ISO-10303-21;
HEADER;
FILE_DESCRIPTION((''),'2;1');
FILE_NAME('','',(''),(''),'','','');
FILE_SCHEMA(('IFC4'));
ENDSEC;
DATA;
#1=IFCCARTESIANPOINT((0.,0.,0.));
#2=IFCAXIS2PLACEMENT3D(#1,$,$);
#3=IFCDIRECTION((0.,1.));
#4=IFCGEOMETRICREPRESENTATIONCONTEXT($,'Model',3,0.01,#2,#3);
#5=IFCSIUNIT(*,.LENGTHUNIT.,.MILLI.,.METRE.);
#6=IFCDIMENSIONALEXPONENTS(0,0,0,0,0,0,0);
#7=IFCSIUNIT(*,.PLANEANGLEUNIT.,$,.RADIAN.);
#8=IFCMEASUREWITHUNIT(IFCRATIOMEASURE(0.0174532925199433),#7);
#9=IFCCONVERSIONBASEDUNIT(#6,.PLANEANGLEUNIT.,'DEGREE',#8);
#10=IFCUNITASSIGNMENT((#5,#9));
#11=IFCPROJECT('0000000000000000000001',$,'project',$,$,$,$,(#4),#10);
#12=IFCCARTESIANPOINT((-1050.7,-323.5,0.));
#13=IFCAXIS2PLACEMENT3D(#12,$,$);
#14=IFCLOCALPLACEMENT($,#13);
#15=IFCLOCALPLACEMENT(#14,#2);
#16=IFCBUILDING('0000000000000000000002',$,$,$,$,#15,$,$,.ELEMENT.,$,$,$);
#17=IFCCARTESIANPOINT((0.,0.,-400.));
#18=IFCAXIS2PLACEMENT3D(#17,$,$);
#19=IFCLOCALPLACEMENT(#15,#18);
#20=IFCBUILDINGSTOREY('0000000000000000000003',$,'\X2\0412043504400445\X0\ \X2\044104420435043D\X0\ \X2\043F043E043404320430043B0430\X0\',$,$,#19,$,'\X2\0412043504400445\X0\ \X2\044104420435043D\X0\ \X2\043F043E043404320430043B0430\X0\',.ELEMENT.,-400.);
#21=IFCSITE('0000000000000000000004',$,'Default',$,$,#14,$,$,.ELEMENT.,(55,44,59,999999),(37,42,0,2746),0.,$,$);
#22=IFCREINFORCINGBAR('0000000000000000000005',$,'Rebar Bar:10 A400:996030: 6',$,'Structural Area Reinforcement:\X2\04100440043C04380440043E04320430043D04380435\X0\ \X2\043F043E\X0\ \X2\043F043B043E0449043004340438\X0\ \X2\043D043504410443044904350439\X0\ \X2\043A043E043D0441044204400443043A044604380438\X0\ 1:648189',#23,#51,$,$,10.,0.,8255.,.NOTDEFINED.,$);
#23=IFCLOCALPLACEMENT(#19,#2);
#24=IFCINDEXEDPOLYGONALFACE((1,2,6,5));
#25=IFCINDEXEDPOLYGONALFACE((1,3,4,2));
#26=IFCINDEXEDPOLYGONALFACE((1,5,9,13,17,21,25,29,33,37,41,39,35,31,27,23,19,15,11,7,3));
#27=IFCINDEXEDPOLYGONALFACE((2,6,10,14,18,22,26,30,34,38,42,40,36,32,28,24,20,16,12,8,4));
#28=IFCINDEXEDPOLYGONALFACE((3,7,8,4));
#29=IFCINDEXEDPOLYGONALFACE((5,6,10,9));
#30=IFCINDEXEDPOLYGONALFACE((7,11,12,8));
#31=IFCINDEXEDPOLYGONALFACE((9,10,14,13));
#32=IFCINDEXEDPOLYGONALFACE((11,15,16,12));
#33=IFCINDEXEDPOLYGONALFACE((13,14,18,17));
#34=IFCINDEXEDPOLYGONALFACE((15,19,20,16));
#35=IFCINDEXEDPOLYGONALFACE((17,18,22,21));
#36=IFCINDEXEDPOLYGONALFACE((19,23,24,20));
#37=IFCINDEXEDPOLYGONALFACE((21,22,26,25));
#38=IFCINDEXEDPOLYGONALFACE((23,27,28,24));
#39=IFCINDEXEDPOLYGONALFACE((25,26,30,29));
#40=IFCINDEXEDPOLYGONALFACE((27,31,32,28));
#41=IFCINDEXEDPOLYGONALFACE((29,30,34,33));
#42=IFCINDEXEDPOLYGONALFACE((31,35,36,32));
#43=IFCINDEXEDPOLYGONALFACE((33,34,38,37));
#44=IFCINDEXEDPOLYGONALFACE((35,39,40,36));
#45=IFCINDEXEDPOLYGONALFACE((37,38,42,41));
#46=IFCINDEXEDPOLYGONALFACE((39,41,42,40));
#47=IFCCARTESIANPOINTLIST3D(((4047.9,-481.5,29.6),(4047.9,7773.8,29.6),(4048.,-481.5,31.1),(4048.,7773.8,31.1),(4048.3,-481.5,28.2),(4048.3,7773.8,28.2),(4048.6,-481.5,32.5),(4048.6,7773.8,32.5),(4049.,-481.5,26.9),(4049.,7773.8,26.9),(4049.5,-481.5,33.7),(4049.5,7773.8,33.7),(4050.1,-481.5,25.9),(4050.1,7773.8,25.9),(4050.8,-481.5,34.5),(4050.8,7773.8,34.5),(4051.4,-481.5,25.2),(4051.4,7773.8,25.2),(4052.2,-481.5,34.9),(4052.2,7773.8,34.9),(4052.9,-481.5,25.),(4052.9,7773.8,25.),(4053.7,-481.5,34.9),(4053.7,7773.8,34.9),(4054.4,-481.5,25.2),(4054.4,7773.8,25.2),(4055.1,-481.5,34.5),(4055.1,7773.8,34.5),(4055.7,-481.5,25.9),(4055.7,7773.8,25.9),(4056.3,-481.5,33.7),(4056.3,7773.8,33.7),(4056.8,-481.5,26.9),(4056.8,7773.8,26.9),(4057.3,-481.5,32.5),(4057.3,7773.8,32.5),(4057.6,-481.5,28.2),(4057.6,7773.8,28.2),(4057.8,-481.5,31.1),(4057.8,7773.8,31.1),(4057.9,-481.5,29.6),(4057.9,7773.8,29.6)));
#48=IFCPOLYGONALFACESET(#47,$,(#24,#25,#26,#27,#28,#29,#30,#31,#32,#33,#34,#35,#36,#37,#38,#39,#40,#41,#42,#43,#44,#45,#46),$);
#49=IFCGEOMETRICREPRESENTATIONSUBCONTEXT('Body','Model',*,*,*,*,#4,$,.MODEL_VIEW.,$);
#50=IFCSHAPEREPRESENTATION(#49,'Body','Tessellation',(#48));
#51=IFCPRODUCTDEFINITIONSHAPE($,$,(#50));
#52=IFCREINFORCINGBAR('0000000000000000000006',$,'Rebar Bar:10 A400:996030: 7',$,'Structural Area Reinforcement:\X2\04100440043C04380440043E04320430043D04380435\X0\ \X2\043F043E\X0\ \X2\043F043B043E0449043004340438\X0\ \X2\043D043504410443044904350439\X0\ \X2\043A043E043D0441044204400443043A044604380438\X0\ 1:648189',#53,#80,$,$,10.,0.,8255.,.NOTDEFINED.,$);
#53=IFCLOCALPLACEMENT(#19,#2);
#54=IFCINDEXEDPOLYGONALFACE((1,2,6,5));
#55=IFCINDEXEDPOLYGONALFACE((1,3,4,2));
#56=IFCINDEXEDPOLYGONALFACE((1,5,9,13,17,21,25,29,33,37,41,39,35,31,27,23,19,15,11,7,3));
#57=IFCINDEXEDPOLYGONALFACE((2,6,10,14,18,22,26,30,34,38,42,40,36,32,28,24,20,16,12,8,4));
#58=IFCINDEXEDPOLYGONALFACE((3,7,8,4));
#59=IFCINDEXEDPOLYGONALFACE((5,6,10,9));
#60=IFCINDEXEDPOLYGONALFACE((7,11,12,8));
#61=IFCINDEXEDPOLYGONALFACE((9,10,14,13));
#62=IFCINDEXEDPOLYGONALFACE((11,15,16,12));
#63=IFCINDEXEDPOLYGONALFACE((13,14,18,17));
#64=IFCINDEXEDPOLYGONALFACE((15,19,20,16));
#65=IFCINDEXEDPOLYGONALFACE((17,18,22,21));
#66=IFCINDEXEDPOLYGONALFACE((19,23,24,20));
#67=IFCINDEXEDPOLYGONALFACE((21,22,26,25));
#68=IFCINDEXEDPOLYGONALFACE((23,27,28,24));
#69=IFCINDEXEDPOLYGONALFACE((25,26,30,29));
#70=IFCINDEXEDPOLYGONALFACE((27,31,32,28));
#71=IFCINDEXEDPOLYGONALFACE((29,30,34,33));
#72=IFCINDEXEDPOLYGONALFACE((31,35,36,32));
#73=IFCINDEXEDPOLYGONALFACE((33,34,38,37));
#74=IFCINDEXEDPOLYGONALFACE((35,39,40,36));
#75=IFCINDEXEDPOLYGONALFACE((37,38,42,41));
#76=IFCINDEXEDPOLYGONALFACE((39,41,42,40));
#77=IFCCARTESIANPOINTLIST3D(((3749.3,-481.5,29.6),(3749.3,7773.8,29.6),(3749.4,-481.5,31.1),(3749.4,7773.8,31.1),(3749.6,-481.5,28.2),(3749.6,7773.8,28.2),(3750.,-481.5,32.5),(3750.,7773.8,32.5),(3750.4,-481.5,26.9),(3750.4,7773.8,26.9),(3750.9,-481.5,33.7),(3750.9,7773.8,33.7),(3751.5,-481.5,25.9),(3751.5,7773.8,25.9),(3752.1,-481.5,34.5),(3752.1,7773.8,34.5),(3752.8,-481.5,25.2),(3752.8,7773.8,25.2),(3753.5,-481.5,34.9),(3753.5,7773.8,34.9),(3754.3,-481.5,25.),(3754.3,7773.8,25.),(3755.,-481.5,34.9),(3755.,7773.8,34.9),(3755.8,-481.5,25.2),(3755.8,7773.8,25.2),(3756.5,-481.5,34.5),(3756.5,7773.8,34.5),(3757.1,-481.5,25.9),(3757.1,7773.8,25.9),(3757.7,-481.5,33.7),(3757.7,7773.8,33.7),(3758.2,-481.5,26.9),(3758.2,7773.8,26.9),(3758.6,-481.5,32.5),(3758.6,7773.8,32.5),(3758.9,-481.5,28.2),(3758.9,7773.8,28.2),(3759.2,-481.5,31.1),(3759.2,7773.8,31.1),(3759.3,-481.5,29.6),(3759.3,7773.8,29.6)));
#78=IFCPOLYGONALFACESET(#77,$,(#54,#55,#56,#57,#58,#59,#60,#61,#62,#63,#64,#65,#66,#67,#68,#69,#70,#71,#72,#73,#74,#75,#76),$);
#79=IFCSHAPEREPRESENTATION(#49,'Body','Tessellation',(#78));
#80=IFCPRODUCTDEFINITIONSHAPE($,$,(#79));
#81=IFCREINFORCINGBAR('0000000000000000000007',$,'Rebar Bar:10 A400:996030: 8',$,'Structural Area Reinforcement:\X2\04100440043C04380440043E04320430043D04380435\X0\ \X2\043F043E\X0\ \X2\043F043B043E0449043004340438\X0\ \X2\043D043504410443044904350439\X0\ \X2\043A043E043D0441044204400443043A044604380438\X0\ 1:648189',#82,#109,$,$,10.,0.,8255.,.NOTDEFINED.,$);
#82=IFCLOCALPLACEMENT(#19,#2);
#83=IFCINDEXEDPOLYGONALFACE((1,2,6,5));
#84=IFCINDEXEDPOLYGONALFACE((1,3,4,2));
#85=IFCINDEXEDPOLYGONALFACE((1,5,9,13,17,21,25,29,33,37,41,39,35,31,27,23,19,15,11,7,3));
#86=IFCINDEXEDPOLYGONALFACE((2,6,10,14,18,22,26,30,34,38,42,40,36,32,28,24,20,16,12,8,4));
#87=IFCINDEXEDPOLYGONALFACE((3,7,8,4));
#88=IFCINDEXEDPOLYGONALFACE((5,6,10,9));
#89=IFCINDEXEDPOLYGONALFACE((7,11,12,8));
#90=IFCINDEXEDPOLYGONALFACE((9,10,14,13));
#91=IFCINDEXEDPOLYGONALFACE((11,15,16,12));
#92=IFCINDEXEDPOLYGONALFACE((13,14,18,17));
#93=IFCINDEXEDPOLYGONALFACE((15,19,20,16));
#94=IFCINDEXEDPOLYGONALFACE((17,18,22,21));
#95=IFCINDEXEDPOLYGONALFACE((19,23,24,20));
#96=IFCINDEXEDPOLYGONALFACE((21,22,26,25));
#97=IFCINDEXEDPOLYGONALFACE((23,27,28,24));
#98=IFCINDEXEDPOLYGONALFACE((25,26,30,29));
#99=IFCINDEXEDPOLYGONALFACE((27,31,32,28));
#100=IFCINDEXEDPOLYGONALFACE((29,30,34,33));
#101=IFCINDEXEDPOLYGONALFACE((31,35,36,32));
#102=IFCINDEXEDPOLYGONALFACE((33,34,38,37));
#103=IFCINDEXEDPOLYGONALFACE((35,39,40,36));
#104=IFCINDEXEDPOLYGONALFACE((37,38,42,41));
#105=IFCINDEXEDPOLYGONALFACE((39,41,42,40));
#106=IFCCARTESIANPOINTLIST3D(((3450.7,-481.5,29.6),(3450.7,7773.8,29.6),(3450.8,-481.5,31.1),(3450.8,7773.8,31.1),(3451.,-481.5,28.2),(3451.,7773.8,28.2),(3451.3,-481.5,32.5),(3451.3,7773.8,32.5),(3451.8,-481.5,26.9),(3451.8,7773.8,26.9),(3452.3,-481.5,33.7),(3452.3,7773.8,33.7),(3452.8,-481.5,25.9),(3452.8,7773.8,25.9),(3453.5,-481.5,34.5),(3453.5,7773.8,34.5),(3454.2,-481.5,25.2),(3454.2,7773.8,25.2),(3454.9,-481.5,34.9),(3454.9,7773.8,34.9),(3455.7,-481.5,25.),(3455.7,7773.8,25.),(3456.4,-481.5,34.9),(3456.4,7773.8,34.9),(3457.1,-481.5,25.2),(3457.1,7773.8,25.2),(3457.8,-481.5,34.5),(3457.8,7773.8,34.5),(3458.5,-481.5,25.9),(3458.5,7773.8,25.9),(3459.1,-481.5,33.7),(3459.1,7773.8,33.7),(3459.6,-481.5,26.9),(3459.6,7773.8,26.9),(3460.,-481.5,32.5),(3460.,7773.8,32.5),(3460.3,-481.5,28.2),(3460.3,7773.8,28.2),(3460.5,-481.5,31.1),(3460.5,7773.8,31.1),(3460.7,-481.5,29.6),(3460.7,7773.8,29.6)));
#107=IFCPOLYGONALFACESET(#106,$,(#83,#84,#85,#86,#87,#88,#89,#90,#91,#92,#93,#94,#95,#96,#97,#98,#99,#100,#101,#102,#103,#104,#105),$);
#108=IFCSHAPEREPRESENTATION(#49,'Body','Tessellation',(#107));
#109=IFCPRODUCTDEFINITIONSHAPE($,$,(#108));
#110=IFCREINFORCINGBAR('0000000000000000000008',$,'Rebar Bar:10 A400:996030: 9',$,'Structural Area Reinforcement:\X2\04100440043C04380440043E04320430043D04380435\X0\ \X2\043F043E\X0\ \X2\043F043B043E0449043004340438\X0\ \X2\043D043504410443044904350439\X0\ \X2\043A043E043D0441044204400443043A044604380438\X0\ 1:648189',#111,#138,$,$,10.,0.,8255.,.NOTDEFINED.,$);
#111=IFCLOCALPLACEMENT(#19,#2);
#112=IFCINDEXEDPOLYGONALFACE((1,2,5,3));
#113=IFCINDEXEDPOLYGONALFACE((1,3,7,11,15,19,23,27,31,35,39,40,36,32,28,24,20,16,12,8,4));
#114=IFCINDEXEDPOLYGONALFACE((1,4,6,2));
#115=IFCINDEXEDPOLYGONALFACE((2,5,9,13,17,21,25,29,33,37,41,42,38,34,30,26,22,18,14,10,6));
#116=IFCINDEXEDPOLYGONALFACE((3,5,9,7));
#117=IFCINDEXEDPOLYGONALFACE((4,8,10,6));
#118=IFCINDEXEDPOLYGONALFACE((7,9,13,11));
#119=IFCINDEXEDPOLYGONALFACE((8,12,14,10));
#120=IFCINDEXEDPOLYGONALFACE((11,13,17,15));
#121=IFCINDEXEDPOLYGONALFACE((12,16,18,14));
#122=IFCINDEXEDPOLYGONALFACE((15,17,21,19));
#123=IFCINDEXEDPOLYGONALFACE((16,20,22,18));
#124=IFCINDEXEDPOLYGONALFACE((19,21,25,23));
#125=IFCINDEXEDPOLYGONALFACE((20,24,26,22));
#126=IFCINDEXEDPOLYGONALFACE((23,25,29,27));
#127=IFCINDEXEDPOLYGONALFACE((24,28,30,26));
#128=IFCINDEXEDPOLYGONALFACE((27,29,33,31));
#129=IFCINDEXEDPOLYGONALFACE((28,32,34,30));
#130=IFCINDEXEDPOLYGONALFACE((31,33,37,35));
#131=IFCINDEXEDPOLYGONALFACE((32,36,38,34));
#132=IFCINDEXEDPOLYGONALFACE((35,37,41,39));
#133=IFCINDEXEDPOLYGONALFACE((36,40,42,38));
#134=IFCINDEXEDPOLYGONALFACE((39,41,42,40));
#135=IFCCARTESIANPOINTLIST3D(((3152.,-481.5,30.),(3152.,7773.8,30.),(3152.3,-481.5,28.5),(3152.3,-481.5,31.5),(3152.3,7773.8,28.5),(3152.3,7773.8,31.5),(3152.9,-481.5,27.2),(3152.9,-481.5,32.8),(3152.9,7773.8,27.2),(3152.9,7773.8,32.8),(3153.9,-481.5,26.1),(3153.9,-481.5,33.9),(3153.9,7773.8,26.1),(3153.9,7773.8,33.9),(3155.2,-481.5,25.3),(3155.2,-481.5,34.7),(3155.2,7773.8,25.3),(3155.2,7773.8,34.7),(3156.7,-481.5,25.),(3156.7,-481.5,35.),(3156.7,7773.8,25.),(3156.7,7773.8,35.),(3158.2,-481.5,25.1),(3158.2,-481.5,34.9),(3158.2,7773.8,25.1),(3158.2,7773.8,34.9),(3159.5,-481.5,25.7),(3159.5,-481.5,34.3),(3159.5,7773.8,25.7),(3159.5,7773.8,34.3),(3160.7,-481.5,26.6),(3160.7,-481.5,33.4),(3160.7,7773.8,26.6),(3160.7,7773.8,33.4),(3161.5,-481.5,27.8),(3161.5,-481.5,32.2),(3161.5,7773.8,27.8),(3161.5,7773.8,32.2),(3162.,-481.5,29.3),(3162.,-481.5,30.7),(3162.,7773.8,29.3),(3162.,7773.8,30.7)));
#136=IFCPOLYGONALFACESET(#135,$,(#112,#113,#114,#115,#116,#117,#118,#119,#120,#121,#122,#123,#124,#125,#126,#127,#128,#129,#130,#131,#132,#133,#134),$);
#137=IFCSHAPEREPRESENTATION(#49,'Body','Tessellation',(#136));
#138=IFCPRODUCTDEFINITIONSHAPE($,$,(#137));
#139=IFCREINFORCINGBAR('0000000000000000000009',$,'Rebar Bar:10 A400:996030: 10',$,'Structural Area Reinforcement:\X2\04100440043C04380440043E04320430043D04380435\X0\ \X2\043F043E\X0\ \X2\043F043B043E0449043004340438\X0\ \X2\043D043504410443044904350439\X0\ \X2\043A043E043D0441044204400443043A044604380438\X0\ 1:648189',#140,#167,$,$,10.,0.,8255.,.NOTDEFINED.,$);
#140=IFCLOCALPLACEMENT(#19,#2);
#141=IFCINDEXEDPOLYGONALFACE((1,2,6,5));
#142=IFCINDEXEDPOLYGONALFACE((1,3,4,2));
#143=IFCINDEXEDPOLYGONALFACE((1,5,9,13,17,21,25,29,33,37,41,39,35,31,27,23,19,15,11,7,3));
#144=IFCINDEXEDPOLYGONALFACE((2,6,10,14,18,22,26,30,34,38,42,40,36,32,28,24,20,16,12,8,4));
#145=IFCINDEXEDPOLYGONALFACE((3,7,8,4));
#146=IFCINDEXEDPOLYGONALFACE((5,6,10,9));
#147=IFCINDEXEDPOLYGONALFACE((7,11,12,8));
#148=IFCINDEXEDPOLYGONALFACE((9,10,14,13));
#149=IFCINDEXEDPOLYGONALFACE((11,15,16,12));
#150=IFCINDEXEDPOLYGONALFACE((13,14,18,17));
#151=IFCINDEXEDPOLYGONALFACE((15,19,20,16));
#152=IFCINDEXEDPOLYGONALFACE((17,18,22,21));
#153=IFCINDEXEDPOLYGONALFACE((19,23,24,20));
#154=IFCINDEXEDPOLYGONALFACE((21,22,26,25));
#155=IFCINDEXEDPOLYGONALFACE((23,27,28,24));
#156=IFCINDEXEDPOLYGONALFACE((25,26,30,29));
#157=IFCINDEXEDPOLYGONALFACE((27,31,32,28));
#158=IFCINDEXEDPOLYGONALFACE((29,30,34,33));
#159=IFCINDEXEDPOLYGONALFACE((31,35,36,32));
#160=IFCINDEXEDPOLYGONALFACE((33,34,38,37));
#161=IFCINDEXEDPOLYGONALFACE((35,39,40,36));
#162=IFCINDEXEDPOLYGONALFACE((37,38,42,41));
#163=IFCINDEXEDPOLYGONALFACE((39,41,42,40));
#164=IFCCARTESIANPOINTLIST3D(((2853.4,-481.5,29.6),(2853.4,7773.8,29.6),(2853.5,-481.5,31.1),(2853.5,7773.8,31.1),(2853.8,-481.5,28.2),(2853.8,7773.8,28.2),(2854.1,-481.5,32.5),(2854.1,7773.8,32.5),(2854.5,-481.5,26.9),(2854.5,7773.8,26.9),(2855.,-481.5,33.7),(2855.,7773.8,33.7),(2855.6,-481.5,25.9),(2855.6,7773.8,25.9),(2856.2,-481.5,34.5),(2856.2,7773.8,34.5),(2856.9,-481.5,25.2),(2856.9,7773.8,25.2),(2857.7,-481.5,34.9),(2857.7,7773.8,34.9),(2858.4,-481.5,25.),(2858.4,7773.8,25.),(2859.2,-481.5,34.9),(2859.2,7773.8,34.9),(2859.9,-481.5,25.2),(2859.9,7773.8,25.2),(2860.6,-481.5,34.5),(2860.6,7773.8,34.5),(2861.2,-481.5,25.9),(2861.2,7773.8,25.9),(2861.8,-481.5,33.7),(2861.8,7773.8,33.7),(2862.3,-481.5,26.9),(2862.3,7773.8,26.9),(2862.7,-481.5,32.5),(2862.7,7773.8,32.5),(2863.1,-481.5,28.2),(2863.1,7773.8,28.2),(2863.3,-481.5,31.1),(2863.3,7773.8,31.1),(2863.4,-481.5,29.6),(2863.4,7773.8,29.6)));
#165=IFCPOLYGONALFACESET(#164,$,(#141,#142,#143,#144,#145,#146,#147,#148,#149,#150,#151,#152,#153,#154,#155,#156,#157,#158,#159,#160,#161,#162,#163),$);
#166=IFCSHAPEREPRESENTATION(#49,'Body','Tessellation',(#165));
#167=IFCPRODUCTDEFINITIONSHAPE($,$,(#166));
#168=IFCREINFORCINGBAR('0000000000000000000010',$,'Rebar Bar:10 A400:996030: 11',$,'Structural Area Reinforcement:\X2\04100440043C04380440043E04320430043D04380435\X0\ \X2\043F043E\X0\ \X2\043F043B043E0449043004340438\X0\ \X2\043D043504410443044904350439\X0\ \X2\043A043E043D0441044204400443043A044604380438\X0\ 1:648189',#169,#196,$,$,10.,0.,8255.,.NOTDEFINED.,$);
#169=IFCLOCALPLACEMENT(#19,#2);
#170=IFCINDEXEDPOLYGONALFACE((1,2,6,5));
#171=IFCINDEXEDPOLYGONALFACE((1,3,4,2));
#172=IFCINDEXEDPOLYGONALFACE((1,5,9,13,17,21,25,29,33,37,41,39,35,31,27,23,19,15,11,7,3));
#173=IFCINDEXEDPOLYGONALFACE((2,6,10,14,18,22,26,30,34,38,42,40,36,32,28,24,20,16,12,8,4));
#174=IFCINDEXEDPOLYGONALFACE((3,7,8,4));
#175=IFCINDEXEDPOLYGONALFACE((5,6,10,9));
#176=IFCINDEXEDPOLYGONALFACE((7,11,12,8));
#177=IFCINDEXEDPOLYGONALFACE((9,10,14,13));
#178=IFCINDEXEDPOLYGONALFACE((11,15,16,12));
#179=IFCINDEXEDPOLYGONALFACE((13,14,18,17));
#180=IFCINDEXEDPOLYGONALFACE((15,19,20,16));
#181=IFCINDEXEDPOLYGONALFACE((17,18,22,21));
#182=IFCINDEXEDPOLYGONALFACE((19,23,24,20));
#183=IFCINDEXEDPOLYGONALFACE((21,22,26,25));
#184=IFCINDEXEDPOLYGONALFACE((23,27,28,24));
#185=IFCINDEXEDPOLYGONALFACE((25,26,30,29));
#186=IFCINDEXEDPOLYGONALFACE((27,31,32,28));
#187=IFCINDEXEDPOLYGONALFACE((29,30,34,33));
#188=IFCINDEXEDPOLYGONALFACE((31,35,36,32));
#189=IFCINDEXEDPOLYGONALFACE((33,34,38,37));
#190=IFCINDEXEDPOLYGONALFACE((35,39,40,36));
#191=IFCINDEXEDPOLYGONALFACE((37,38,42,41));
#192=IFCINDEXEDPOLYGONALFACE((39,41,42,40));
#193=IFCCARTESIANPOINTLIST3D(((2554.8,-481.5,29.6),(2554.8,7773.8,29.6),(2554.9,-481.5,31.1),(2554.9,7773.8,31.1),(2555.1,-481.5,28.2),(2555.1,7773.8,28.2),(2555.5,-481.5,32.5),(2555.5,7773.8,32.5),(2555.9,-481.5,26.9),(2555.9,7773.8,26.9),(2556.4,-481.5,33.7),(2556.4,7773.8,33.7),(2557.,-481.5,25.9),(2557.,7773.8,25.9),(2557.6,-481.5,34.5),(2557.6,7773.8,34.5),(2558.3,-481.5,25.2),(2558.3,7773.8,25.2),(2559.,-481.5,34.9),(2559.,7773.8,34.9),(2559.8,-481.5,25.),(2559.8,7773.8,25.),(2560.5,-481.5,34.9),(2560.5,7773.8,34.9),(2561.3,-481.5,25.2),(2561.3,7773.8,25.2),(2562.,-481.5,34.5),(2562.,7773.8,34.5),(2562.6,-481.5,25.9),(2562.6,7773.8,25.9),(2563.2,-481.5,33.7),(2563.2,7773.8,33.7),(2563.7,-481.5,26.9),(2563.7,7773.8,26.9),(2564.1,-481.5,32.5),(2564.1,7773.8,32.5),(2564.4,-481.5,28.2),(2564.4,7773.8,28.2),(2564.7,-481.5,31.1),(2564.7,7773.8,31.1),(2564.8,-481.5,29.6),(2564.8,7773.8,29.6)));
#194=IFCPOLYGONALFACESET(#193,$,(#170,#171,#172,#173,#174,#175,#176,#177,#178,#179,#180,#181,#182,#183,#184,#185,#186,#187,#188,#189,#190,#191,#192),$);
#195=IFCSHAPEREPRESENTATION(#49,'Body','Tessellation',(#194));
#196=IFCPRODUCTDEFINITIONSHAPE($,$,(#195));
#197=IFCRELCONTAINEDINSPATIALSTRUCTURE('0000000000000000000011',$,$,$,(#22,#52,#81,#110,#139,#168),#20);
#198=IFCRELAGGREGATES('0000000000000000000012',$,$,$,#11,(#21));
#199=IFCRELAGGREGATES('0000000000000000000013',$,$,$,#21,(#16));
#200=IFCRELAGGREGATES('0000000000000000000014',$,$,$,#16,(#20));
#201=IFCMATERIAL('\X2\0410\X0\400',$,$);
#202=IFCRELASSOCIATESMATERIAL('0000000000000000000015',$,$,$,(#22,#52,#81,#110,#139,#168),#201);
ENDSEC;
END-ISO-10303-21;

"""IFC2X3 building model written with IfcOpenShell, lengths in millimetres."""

from ifc_helpers import new_model, entity, si_unit, converted_unit, direction, frame, origin, place, context, subcontext, project, spatial, material, element, save


model = new_model("IFC2X3")

# Units and contexts
model_context = context("Model", 3, precision=0.01, world=origin(), true_north=direction((0.0, 1.0)))
body_context = subcontext(model_context, "Body", "Model", "MODEL_VIEW")
ifc_project = project(units=[si_unit("LENGTHUNIT", "METRE", prefix="MILLI"), converted_unit("PLANEANGLEUNIT", "DEGREE", entity("IfcRatioMeasure", 0.0174532925199433), si_unit("PLANEANGLEUNIT", "RADIAN"), dimensions=[0, 0, 0, 0, 0, 0, 0])], contexts=[model_context])

# Site, building, storey
site_placement = place(None, frame((-1050.7, -323.5, 0.0)))
site = spatial("IfcSite", under=ifc_project, at=site_placement, Name="Default", CompositionType="ELEMENT", RefLatitude=(55, 44, 59, 999999), RefLongitude=(37, 42, 0, 2746), RefElevation=0.0)
building_placement = place(site_placement, origin())
building = spatial("IfcBuilding", under=site, at=building_placement, CompositionType="ELEMENT")
storey_placement = place(building_placement, frame((0.0, 0.0, -400.0)))
storey = spatial("IfcBuildingStorey", under=building, at=storey_placement, Name="Верх стен подвала", LongName="Верх стен подвала", CompositionType="ELEMENT", Elevation=-400.0)

# Reinforcing bars
ifc_material = material(Name="А400")
reinforcing_bar_1_placement = place(storey_placement, origin())
element("IfcReinforcingBar", 1, at=reinforcing_bar_1_placement, inside=storey, material=ifc_material, Name="Rebar Bar:10 A400:996030: 6", ObjectType="Structural Area Reinforcement:Армирование по площади несущей конструкции 1:648189", BarLength=8255.0, BarRole="NOTDEFINED", CrossSectionArea=0.0, NominalDiameter=10.0, context=body_context, shape_type="AdvancedSweptSolid", body=[
    entity("IfcSweptDiskSolid", entity("IfcCompositeCurve", [entity("IfcCompositeCurveSegment", "CONTINUOUS", True, entity("IfcPolyline", [entity("IfcCartesianPoint", [4052.9, 7773.8, 30.0]), entity("IfcCartesianPoint", [4052.9, -481.5, 30.0])]))], False), 5.0, None, 0.0, 1.0),
])
reinforcing_bar_2_placement = place(storey_placement, origin())
element("IfcReinforcingBar", 2, at=reinforcing_bar_2_placement, inside=storey, material=ifc_material, Name="Rebar Bar:10 A400:996030: 7", ObjectType="Structural Area Reinforcement:Армирование по площади несущей конструкции 1:648189", BarLength=8255.0, BarRole="NOTDEFINED", CrossSectionArea=0.0, NominalDiameter=10.0, context=body_context, shape_type="AdvancedSweptSolid", body=[
    entity("IfcSweptDiskSolid", entity("IfcCompositeCurve", [entity("IfcCompositeCurveSegment", "CONTINUOUS", True, entity("IfcPolyline", [entity("IfcCartesianPoint", [3754.3, 7773.8, 30.0]), entity("IfcCartesianPoint", [3754.3, -481.5, 30.0])]))], False), 5.0, None, 0.0, 1.0),
])
reinforcing_bar_3_placement = place(storey_placement, origin())
element("IfcReinforcingBar", 3, at=reinforcing_bar_3_placement, inside=storey, material=ifc_material, Name="Rebar Bar:10 A400:996030: 8", ObjectType="Structural Area Reinforcement:Армирование по площади несущей конструкции 1:648189", BarLength=8255.0, BarRole="NOTDEFINED", CrossSectionArea=0.0, NominalDiameter=10.0, context=body_context, shape_type="AdvancedSweptSolid", body=[
    entity("IfcSweptDiskSolid", entity("IfcCompositeCurve", [entity("IfcCompositeCurveSegment", "CONTINUOUS", True, entity("IfcPolyline", [entity("IfcCartesianPoint", [3455.7, 7773.8, 30.0]), entity("IfcCartesianPoint", [3455.7, -481.5, 30.0])]))], False), 5.0, None, 0.0, 1.0),
])
reinforcing_bar_4_placement = place(storey_placement, origin())
element("IfcReinforcingBar", 4, at=reinforcing_bar_4_placement, inside=storey, material=ifc_material, Name="Rebar Bar:10 A400:996030: 9", ObjectType="Structural Area Reinforcement:Армирование по площади несущей конструкции 1:648189", BarLength=8255.0, BarRole="NOTDEFINED", CrossSectionArea=0.0, NominalDiameter=10.0, context=body_context, shape_type="AdvancedSweptSolid", body=[
    entity("IfcSweptDiskSolid", entity("IfcCompositeCurve", [entity("IfcCompositeCurveSegment", "CONTINUOUS", True, entity("IfcPolyline", [entity("IfcCartesianPoint", [3157.0, 7773.8, 30.0]), entity("IfcCartesianPoint", [3157.0, -481.5, 30.0])]))], False), 5.0, None, 0.0, 1.0),
])
reinforcing_bar_5_placement = place(storey_placement, origin())
element("IfcReinforcingBar", 5, at=reinforcing_bar_5_placement, inside=storey, material=ifc_material, Name="Rebar Bar:10 A400:996030: 10", ObjectType="Structural Area Reinforcement:Армирование по площади несущей конструкции 1:648189", BarLength=8255.0, BarRole="NOTDEFINED", CrossSectionArea=0.0, NominalDiameter=10.0, context=body_context, shape_type="AdvancedSweptSolid", body=[
    entity("IfcSweptDiskSolid", entity("IfcCompositeCurve", [entity("IfcCompositeCurveSegment", "CONTINUOUS", True, entity("IfcPolyline", [entity("IfcCartesianPoint", [2858.4, 7773.8, 30.0]), entity("IfcCartesianPoint", [2858.4, -481.5, 30.0])]))], False), 5.0, None, 0.0, 1.0),
])
reinforcing_bar_6_placement = place(storey_placement, origin())
element("IfcReinforcingBar", 6, at=reinforcing_bar_6_placement, inside=storey, material=ifc_material, Name="Rebar Bar:10 A400:996030: 11", ObjectType="Structural Area Reinforcement:Армирование по площади несущей конструкции 1:648189", BarLength=8255.0, BarRole="NOTDEFINED", CrossSectionArea=0.0, NominalDiameter=10.0, context=body_context, shape_type="AdvancedSweptSolid", body=[
    entity("IfcSweptDiskSolid", entity("IfcCompositeCurve", [entity("IfcCompositeCurveSegment", "CONTINUOUS", True, entity("IfcPolyline", [entity("IfcCartesianPoint", [2559.8, 7773.8, 30.0]), entity("IfcCartesianPoint", [2559.8, -481.5, 30.0])]))], False), 5.0, None, 0.0, 1.0),
])

save(model, "model.ifc")
